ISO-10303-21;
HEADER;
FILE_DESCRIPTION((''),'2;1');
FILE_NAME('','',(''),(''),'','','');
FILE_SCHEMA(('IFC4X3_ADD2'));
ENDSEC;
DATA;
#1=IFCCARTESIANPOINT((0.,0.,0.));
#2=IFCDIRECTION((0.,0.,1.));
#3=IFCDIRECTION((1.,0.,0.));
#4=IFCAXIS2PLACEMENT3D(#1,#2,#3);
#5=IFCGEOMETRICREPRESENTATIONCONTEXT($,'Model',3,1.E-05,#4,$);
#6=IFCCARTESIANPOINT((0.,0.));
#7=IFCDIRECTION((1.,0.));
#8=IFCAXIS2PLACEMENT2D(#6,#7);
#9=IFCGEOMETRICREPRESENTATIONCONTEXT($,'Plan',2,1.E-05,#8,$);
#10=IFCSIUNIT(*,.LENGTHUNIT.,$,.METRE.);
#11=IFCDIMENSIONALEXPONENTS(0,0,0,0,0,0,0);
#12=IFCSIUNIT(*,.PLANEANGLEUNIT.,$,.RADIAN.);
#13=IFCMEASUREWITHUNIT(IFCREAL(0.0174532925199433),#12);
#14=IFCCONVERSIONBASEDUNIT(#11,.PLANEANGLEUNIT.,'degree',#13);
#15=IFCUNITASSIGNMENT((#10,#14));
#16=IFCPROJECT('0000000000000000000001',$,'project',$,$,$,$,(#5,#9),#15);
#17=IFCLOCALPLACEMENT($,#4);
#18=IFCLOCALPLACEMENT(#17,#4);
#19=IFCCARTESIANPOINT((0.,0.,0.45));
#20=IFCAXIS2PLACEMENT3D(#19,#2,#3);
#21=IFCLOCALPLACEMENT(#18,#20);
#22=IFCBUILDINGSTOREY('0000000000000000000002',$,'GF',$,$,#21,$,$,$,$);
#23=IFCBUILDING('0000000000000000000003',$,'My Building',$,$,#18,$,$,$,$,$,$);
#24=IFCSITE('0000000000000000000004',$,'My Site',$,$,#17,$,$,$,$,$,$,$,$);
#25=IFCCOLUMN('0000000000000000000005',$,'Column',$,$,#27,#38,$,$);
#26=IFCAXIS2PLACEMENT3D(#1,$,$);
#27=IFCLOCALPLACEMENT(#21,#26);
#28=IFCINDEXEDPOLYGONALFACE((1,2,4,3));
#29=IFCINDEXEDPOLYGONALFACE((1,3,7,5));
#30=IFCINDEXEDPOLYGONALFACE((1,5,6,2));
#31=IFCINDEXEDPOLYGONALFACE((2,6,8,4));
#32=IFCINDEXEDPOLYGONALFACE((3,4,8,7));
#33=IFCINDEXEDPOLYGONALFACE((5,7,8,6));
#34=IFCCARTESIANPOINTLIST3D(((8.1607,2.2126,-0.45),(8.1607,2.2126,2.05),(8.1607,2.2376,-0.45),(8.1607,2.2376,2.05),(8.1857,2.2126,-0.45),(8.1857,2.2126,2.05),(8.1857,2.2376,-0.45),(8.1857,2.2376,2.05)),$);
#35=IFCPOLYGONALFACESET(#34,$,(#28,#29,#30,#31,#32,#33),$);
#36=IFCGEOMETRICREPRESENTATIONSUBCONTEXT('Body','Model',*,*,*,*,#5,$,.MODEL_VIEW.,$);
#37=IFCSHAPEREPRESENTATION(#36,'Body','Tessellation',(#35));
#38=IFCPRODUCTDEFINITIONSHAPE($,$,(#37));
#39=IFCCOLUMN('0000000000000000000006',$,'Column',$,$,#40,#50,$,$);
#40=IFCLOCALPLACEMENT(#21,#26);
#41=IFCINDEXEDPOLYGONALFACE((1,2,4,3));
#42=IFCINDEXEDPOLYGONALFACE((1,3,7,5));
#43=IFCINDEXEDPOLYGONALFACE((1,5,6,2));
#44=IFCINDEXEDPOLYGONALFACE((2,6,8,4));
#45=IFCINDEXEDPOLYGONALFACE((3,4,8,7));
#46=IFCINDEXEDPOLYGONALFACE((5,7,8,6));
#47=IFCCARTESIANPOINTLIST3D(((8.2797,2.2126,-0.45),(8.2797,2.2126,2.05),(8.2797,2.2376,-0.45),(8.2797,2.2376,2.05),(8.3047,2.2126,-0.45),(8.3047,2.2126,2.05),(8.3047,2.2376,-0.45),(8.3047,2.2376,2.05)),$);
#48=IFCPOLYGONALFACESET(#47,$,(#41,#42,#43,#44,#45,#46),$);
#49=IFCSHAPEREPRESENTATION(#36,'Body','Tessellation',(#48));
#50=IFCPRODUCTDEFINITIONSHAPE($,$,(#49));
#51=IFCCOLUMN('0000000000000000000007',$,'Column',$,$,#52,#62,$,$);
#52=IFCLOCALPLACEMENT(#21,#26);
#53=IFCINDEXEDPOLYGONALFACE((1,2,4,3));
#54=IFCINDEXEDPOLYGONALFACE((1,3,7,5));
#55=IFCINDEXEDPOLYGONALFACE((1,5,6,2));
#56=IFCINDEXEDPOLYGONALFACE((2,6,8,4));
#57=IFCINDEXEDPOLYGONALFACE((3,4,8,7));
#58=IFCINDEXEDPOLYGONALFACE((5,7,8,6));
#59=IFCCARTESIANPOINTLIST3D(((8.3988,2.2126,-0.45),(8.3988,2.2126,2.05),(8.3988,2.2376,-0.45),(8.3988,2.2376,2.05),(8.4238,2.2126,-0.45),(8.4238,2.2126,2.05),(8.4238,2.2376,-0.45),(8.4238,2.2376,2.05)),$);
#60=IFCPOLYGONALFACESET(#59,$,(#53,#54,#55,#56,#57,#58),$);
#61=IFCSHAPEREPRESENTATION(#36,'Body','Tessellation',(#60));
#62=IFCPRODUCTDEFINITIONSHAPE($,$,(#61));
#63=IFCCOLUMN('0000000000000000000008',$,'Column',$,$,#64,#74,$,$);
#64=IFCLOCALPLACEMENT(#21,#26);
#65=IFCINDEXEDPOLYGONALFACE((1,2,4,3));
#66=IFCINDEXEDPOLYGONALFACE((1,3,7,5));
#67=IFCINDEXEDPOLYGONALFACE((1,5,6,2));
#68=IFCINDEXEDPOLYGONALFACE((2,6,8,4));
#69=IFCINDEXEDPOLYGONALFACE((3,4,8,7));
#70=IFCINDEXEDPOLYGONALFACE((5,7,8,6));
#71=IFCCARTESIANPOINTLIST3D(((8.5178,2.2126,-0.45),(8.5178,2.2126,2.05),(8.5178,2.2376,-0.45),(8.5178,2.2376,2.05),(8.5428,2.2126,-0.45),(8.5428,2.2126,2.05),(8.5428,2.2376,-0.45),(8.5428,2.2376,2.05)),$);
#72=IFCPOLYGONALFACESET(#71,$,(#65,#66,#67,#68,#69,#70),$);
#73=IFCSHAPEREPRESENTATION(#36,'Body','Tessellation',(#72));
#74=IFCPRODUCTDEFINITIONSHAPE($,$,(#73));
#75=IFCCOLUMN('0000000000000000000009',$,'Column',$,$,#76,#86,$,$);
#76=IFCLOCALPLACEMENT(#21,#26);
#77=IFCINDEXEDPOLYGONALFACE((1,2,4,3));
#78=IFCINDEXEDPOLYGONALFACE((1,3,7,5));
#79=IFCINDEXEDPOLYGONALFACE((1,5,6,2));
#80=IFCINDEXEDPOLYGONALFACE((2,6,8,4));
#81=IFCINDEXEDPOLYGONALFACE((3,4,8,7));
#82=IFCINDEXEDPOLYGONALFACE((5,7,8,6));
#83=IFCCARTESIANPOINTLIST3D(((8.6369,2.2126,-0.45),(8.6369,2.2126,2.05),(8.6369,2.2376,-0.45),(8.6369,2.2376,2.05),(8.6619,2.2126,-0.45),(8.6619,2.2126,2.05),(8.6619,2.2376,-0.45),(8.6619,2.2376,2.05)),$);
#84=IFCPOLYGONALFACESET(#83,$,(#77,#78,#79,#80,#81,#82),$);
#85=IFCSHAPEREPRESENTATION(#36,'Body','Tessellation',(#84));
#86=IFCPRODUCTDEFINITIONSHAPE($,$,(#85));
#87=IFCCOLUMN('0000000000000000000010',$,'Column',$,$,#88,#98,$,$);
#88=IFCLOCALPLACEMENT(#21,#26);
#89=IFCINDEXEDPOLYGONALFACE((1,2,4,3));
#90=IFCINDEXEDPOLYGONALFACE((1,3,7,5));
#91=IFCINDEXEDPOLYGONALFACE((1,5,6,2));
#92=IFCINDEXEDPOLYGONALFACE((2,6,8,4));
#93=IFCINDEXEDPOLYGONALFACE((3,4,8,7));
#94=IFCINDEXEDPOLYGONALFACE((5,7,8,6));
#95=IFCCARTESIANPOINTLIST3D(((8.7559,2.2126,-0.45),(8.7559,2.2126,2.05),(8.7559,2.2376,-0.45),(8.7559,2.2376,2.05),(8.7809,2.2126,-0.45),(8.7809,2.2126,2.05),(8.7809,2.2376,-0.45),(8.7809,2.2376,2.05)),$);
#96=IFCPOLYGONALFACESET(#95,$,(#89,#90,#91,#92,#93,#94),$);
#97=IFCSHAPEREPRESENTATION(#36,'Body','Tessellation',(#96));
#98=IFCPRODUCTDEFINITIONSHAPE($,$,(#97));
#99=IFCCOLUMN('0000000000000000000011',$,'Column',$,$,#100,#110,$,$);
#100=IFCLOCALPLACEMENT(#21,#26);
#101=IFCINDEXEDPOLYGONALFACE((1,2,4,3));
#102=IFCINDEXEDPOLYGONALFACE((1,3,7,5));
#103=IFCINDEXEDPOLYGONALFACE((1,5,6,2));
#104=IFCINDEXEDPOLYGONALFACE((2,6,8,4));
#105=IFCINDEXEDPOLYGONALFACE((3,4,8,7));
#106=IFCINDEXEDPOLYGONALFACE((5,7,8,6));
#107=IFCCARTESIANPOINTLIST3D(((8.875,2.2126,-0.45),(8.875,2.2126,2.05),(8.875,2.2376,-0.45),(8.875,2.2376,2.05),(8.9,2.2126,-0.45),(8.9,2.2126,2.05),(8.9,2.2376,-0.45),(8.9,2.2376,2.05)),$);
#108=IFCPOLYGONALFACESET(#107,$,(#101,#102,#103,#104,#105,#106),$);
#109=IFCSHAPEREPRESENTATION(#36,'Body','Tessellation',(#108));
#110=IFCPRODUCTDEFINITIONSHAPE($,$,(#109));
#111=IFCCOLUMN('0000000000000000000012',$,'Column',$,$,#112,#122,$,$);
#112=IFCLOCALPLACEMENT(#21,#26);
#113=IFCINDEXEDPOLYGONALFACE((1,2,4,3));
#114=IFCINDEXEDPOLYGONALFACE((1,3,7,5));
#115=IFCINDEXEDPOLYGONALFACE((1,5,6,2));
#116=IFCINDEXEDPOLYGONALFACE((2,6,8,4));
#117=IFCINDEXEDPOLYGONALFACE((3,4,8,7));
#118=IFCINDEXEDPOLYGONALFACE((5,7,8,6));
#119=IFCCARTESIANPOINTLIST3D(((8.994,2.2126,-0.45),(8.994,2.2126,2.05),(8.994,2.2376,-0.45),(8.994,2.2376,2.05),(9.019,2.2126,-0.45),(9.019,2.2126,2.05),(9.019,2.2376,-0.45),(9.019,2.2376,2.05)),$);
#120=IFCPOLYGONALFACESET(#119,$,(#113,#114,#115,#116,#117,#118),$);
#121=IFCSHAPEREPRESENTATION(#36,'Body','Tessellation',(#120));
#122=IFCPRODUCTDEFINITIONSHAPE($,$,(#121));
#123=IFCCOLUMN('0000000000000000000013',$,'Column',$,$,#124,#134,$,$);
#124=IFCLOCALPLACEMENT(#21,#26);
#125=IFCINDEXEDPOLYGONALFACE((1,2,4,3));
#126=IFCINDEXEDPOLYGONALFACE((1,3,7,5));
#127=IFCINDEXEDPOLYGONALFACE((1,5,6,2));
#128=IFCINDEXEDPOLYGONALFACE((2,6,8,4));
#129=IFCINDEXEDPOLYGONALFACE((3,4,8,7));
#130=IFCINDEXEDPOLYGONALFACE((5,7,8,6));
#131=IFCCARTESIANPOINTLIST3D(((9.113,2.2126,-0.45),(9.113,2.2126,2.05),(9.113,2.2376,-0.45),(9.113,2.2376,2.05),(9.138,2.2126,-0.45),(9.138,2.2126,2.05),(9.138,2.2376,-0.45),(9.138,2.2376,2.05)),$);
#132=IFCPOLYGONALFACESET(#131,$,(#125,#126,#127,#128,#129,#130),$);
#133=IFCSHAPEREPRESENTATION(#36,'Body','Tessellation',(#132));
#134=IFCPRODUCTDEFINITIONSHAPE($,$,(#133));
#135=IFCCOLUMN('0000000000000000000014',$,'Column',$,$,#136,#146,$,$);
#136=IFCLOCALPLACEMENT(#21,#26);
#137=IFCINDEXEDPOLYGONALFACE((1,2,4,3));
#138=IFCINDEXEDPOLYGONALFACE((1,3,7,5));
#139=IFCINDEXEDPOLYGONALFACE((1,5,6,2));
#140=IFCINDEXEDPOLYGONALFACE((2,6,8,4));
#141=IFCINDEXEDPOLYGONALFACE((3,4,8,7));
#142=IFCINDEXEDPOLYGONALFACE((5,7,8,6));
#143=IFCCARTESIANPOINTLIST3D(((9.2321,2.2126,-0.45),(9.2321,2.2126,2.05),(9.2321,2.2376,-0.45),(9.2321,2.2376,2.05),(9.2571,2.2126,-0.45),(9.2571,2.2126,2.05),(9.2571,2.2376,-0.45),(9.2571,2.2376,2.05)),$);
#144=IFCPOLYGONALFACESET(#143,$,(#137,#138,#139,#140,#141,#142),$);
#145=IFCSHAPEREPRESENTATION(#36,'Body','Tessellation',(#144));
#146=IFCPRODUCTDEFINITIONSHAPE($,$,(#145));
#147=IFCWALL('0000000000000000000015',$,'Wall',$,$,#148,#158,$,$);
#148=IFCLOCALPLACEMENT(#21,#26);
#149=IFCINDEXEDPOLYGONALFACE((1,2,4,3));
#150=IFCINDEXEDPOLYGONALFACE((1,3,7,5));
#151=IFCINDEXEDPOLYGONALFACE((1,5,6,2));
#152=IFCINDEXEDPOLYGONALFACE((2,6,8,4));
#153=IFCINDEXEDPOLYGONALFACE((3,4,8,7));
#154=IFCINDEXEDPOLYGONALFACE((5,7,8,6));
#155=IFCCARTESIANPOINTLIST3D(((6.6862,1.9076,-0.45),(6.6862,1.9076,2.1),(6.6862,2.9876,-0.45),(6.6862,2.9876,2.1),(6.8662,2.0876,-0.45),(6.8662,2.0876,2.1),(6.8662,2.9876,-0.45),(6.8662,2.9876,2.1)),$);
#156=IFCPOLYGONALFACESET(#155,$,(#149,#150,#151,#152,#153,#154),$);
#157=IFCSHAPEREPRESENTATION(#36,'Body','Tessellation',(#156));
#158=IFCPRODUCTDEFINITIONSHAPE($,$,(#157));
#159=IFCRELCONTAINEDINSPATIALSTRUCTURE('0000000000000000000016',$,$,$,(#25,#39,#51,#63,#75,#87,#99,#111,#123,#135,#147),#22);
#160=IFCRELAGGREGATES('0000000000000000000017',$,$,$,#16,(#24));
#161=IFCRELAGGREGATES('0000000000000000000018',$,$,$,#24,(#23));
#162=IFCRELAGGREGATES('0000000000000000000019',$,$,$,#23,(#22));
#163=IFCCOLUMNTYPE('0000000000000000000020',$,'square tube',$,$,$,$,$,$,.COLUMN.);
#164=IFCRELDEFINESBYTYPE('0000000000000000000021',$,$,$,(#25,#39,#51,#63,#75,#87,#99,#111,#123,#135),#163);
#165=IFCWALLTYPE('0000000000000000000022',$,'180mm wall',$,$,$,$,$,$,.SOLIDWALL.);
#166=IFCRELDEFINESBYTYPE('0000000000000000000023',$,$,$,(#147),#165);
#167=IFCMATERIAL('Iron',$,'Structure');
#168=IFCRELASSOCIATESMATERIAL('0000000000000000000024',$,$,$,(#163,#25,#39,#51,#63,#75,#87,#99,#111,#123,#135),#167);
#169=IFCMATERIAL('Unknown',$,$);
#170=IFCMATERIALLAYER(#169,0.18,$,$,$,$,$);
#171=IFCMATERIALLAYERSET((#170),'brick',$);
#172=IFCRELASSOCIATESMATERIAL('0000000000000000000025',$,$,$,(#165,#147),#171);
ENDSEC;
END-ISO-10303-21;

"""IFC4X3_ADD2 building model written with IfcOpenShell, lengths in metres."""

from ifc_helpers import new_model, entity, si_unit, converted_unit, frame, origin_with_axes, origin_2d_with_axis, place, context, subcontext, project, spatial, line, indexed_curve, outline, extrude, material, layer, layer_set, layer_usage, material_profile, profile_set, profile_usage, type_object, element, save


model = new_model("IFC4X3_ADD2")

# Units and contexts
model_context = context("Model", 3, precision=1e-05, world=origin_with_axes())
plan_context = context("Plan", 2, precision=1e-05, world=origin_2d_with_axis())
body_context_1 = subcontext(model_context, "Body", "Model", "MODEL_VIEW")
ifc_project = project(units=[si_unit("LENGTHUNIT", "METRE"), converted_unit("PLANEANGLEUNIT", "degree", entity("IfcReal", 0.0174532925199433), si_unit("PLANEANGLEUNIT", "RADIAN"), dimensions=[0, 0, 0, 0, 0, 0, 0])], contexts=[model_context, plan_context])

# Site, building, storey
site_placement = place(None, origin_with_axes())
site = spatial("IfcSite", under=ifc_project, at=site_placement, Name="My Site")
building_placement = place(site_placement, origin_with_axes())
building = spatial("IfcBuilding", under=site, at=building_placement, Name="My Building")
storey_placement = place(building_placement, frame((0.0, 0.0, 0.45), z_axis=(0.0, 0.0, 1.0), x_axis=(1.0, 0.0, 0.0)))
storey = spatial("IfcBuildingStorey", under=building, at=storey_placement, Name="GF")

# Columns
ifc_material_1 = material(Name="Iron", Category="Structure")
ifc_material_profile = material_profile(ifc_material_1, outline(indexed_curve([(-0.0125, -0.0125), (0.0125, -0.0125), (0.0125, 0.0125), (-0.0125, 0.0125), (-0.0125, -0.0125)])))
ifc_profile_set = profile_set([ifc_material_profile])
column_type = type_object("IfcColumnType", Name="square tube", PredefinedType="COLUMN", material=ifc_profile_set)
ifc_profile_usage_1 = profile_usage(ifc_profile_set, cardinal=5)
column_1_placement = place(storey_placement, frame((8.1732, 2.2251, -0.45), z_axis=(0.0, 0.0, 1.0), x_axis=(1.0, 0.0, 0.0)))
element("IfcColumn", 1, at=column_1_placement, inside=storey, type_object=column_type, material=ifc_profile_usage_1, Name="Column", context=body_context_1, shape_type="SweptSolid", body=[
    extrude(outline(indexed_curve([(-0.0125, -0.0125), (0.0125, -0.0125), (0.0125, 0.0125), (-0.0125, 0.0125), (-0.0125, -0.0125)])), origin_with_axes(), (0.0, 0.0, 1.0), 2.5),
])
ifc_profile_usage_2 = profile_usage(ifc_profile_set, cardinal=5)
column_2_placement = place(storey_placement, frame((8.2922, 2.2251, -0.45), z_axis=(0.0, 0.0, 1.0), x_axis=(1.0, 0.0, 0.0)))
element("IfcColumn", 2, at=column_2_placement, inside=storey, type_object=column_type, material=ifc_profile_usage_2, Name="Column", context=body_context_1, shape_type="SweptSolid", body=[
    extrude(outline(indexed_curve([(-0.0125, -0.0125), (0.0125, -0.0125), (0.0125, 0.0125), (-0.0125, 0.0125), (-0.0125, -0.0125)])), origin_with_axes(), (0.0, 0.0, 1.0), 2.5),
])
ifc_profile_usage_3 = profile_usage(ifc_profile_set, cardinal=5)
column_3_placement = place(storey_placement, frame((8.4113, 2.2251, -0.45), z_axis=(0.0, 0.0, 1.0), x_axis=(1.0, 0.0, 0.0)))
element("IfcColumn", 3, at=column_3_placement, inside=storey, type_object=column_type, material=ifc_profile_usage_3, Name="Column", context=body_context_1, shape_type="SweptSolid", body=[
    extrude(outline(indexed_curve([(-0.0125, -0.0125), (0.0125, -0.0125), (0.0125, 0.0125), (-0.0125, 0.0125), (-0.0125, -0.0125)])), origin_with_axes(), (0.0, 0.0, 1.0), 2.5),
])
ifc_profile_usage_4 = profile_usage(ifc_profile_set, cardinal=5)
column_4_placement = place(storey_placement, frame((8.5303, 2.2251, -0.45), z_axis=(0.0, 0.0, 1.0), x_axis=(1.0, 0.0, 0.0)))
element("IfcColumn", 4, at=column_4_placement, inside=storey, type_object=column_type, material=ifc_profile_usage_4, Name="Column", context=body_context_1, shape_type="SweptSolid", body=[
    extrude(outline(indexed_curve([(-0.0125, -0.0125), (0.0125, -0.0125), (0.0125, 0.0125), (-0.0125, 0.0125), (-0.0125, -0.0125)])), origin_with_axes(), (0.0, 0.0, 1.0), 2.5),
])
ifc_profile_usage_5 = profile_usage(ifc_profile_set, cardinal=5)
column_5_placement = place(storey_placement, frame((8.6494, 2.2251, -0.45), z_axis=(0.0, 0.0, 1.0), x_axis=(1.0, 0.0, 0.0)))
element("IfcColumn", 5, at=column_5_placement, inside=storey, type_object=column_type, material=ifc_profile_usage_5, Name="Column", context=body_context_1, shape_type="SweptSolid", body=[
    extrude(outline(indexed_curve([(-0.0125, -0.0125), (0.0125, -0.0125), (0.0125, 0.0125), (-0.0125, 0.0125), (-0.0125, -0.0125)])), origin_with_axes(), (0.0, 0.0, 1.0), 2.5),
])
ifc_profile_usage_6 = profile_usage(ifc_profile_set, cardinal=5)
column_6_placement = place(storey_placement, frame((8.7684, 2.2251, -0.45), z_axis=(0.0, 0.0, 1.0), x_axis=(1.0, 0.0, 0.0)))
element("IfcColumn", 6, at=column_6_placement, inside=storey, type_object=column_type, material=ifc_profile_usage_6, Name="Column", context=body_context_1, shape_type="SweptSolid", body=[
    extrude(outline(indexed_curve([(-0.0125, -0.0125), (0.0125, -0.0125), (0.0125, 0.0125), (-0.0125, 0.0125), (-0.0125, -0.0125)])), origin_with_axes(), (0.0, 0.0, 1.0), 2.5),
])
ifc_profile_usage_7 = profile_usage(ifc_profile_set, cardinal=5)
column_7_placement = place(storey_placement, frame((8.8875, 2.2251, -0.45), z_axis=(0.0, 0.0, 1.0), x_axis=(1.0, 0.0, 0.0)))
element("IfcColumn", 7, at=column_7_placement, inside=storey, type_object=column_type, material=ifc_profile_usage_7, Name="Column", context=body_context_1, shape_type="SweptSolid", body=[
    extrude(outline(indexed_curve([(-0.0125, -0.0125), (0.0125, -0.0125), (0.0125, 0.0125), (-0.0125, 0.0125), (-0.0125, -0.0125)])), origin_with_axes(), (0.0, 0.0, 1.0), 2.5),
])
ifc_profile_usage_8 = profile_usage(ifc_profile_set, cardinal=5)
column_8_placement = place(storey_placement, frame((9.0065, 2.2251, -0.45), z_axis=(0.0, 0.0, 1.0), x_axis=(1.0, 0.0, 0.0)))
element("IfcColumn", 8, at=column_8_placement, inside=storey, type_object=column_type, material=ifc_profile_usage_8, Name="Column", context=body_context_1, shape_type="SweptSolid", body=[
    extrude(outline(indexed_curve([(-0.0125, -0.0125), (0.0125, -0.0125), (0.0125, 0.0125), (-0.0125, 0.0125), (-0.0125, -0.0125)])), origin_with_axes(), (0.0, 0.0, 1.0), 2.5),
])
ifc_profile_usage_9 = profile_usage(ifc_profile_set, cardinal=5)
column_9_placement = place(storey_placement, frame((9.1255, 2.2251, -0.45), z_axis=(0.0, 0.0, 1.0), x_axis=(1.0, 0.0, 0.0)))
element("IfcColumn", 9, at=column_9_placement, inside=storey, type_object=column_type, material=ifc_profile_usage_9, Name="Column", context=body_context_1, shape_type="SweptSolid", body=[
    extrude(outline(indexed_curve([(-0.0125, -0.0125), (0.0125, -0.0125), (0.0125, 0.0125), (-0.0125, 0.0125), (-0.0125, -0.0125)])), origin_with_axes(), (0.0, 0.0, 1.0), 2.5),
])
ifc_profile_usage_10 = profile_usage(ifc_profile_set, cardinal=5)
column_10_placement = place(storey_placement, frame((9.2446, 2.2251, -0.45), z_axis=(0.0, 0.0, 1.0), x_axis=(1.0, 0.0, 0.0)))
element("IfcColumn", 10, at=column_10_placement, inside=storey, type_object=column_type, material=ifc_profile_usage_10, Name="Column", context=body_context_1, shape_type="SweptSolid", body=[
    extrude(outline(indexed_curve([(-0.0125, -0.0125), (0.0125, -0.0125), (0.0125, 0.0125), (-0.0125, 0.0125), (-0.0125, -0.0125)])), origin_with_axes(), (0.0, 0.0, 1.0), 2.5),
])

# Wall
ifc_material_2 = material(Name="Unknown")
ifc_layer_1 = layer(ifc_material_2, 0.18)
ifc_layer_set_1 = layer_set([ifc_layer_1], Name="brick")
ifc_layer_usage_1 = layer_usage(ifc_layer_set_1, "AXIS2", "POSITIVE", 0.0)
wall_type = type_object("IfcWallType", Name="180mm wall", PredefinedType="SOLIDWALL", material=ifc_layer_set_1)
wall_1_placement = place(storey_placement, frame((6.8662, 2.0876, -0.45), z_axis=(0.0, 0.0, 1.0), x_axis=(0.0, 1.0, 0.0)))
element("IfcWall", 11, at=wall_1_placement, inside=storey, type_object=wall_type, material=ifc_layer_usage_1, Name="Wall", context=body_context_1, shape_type="SweptSolid", body=[
    extrude(outline(indexed_curve([(0.0, 0.0), (-0.18, 0.18), (0.9, 0.18), (0.9, 0.0)], segments=[line(1, 2, 3, 4, 1)])), origin_with_axes(), (0.0, 0.0, 1.0), 2.55),
])

save(model, "model.ifc")
